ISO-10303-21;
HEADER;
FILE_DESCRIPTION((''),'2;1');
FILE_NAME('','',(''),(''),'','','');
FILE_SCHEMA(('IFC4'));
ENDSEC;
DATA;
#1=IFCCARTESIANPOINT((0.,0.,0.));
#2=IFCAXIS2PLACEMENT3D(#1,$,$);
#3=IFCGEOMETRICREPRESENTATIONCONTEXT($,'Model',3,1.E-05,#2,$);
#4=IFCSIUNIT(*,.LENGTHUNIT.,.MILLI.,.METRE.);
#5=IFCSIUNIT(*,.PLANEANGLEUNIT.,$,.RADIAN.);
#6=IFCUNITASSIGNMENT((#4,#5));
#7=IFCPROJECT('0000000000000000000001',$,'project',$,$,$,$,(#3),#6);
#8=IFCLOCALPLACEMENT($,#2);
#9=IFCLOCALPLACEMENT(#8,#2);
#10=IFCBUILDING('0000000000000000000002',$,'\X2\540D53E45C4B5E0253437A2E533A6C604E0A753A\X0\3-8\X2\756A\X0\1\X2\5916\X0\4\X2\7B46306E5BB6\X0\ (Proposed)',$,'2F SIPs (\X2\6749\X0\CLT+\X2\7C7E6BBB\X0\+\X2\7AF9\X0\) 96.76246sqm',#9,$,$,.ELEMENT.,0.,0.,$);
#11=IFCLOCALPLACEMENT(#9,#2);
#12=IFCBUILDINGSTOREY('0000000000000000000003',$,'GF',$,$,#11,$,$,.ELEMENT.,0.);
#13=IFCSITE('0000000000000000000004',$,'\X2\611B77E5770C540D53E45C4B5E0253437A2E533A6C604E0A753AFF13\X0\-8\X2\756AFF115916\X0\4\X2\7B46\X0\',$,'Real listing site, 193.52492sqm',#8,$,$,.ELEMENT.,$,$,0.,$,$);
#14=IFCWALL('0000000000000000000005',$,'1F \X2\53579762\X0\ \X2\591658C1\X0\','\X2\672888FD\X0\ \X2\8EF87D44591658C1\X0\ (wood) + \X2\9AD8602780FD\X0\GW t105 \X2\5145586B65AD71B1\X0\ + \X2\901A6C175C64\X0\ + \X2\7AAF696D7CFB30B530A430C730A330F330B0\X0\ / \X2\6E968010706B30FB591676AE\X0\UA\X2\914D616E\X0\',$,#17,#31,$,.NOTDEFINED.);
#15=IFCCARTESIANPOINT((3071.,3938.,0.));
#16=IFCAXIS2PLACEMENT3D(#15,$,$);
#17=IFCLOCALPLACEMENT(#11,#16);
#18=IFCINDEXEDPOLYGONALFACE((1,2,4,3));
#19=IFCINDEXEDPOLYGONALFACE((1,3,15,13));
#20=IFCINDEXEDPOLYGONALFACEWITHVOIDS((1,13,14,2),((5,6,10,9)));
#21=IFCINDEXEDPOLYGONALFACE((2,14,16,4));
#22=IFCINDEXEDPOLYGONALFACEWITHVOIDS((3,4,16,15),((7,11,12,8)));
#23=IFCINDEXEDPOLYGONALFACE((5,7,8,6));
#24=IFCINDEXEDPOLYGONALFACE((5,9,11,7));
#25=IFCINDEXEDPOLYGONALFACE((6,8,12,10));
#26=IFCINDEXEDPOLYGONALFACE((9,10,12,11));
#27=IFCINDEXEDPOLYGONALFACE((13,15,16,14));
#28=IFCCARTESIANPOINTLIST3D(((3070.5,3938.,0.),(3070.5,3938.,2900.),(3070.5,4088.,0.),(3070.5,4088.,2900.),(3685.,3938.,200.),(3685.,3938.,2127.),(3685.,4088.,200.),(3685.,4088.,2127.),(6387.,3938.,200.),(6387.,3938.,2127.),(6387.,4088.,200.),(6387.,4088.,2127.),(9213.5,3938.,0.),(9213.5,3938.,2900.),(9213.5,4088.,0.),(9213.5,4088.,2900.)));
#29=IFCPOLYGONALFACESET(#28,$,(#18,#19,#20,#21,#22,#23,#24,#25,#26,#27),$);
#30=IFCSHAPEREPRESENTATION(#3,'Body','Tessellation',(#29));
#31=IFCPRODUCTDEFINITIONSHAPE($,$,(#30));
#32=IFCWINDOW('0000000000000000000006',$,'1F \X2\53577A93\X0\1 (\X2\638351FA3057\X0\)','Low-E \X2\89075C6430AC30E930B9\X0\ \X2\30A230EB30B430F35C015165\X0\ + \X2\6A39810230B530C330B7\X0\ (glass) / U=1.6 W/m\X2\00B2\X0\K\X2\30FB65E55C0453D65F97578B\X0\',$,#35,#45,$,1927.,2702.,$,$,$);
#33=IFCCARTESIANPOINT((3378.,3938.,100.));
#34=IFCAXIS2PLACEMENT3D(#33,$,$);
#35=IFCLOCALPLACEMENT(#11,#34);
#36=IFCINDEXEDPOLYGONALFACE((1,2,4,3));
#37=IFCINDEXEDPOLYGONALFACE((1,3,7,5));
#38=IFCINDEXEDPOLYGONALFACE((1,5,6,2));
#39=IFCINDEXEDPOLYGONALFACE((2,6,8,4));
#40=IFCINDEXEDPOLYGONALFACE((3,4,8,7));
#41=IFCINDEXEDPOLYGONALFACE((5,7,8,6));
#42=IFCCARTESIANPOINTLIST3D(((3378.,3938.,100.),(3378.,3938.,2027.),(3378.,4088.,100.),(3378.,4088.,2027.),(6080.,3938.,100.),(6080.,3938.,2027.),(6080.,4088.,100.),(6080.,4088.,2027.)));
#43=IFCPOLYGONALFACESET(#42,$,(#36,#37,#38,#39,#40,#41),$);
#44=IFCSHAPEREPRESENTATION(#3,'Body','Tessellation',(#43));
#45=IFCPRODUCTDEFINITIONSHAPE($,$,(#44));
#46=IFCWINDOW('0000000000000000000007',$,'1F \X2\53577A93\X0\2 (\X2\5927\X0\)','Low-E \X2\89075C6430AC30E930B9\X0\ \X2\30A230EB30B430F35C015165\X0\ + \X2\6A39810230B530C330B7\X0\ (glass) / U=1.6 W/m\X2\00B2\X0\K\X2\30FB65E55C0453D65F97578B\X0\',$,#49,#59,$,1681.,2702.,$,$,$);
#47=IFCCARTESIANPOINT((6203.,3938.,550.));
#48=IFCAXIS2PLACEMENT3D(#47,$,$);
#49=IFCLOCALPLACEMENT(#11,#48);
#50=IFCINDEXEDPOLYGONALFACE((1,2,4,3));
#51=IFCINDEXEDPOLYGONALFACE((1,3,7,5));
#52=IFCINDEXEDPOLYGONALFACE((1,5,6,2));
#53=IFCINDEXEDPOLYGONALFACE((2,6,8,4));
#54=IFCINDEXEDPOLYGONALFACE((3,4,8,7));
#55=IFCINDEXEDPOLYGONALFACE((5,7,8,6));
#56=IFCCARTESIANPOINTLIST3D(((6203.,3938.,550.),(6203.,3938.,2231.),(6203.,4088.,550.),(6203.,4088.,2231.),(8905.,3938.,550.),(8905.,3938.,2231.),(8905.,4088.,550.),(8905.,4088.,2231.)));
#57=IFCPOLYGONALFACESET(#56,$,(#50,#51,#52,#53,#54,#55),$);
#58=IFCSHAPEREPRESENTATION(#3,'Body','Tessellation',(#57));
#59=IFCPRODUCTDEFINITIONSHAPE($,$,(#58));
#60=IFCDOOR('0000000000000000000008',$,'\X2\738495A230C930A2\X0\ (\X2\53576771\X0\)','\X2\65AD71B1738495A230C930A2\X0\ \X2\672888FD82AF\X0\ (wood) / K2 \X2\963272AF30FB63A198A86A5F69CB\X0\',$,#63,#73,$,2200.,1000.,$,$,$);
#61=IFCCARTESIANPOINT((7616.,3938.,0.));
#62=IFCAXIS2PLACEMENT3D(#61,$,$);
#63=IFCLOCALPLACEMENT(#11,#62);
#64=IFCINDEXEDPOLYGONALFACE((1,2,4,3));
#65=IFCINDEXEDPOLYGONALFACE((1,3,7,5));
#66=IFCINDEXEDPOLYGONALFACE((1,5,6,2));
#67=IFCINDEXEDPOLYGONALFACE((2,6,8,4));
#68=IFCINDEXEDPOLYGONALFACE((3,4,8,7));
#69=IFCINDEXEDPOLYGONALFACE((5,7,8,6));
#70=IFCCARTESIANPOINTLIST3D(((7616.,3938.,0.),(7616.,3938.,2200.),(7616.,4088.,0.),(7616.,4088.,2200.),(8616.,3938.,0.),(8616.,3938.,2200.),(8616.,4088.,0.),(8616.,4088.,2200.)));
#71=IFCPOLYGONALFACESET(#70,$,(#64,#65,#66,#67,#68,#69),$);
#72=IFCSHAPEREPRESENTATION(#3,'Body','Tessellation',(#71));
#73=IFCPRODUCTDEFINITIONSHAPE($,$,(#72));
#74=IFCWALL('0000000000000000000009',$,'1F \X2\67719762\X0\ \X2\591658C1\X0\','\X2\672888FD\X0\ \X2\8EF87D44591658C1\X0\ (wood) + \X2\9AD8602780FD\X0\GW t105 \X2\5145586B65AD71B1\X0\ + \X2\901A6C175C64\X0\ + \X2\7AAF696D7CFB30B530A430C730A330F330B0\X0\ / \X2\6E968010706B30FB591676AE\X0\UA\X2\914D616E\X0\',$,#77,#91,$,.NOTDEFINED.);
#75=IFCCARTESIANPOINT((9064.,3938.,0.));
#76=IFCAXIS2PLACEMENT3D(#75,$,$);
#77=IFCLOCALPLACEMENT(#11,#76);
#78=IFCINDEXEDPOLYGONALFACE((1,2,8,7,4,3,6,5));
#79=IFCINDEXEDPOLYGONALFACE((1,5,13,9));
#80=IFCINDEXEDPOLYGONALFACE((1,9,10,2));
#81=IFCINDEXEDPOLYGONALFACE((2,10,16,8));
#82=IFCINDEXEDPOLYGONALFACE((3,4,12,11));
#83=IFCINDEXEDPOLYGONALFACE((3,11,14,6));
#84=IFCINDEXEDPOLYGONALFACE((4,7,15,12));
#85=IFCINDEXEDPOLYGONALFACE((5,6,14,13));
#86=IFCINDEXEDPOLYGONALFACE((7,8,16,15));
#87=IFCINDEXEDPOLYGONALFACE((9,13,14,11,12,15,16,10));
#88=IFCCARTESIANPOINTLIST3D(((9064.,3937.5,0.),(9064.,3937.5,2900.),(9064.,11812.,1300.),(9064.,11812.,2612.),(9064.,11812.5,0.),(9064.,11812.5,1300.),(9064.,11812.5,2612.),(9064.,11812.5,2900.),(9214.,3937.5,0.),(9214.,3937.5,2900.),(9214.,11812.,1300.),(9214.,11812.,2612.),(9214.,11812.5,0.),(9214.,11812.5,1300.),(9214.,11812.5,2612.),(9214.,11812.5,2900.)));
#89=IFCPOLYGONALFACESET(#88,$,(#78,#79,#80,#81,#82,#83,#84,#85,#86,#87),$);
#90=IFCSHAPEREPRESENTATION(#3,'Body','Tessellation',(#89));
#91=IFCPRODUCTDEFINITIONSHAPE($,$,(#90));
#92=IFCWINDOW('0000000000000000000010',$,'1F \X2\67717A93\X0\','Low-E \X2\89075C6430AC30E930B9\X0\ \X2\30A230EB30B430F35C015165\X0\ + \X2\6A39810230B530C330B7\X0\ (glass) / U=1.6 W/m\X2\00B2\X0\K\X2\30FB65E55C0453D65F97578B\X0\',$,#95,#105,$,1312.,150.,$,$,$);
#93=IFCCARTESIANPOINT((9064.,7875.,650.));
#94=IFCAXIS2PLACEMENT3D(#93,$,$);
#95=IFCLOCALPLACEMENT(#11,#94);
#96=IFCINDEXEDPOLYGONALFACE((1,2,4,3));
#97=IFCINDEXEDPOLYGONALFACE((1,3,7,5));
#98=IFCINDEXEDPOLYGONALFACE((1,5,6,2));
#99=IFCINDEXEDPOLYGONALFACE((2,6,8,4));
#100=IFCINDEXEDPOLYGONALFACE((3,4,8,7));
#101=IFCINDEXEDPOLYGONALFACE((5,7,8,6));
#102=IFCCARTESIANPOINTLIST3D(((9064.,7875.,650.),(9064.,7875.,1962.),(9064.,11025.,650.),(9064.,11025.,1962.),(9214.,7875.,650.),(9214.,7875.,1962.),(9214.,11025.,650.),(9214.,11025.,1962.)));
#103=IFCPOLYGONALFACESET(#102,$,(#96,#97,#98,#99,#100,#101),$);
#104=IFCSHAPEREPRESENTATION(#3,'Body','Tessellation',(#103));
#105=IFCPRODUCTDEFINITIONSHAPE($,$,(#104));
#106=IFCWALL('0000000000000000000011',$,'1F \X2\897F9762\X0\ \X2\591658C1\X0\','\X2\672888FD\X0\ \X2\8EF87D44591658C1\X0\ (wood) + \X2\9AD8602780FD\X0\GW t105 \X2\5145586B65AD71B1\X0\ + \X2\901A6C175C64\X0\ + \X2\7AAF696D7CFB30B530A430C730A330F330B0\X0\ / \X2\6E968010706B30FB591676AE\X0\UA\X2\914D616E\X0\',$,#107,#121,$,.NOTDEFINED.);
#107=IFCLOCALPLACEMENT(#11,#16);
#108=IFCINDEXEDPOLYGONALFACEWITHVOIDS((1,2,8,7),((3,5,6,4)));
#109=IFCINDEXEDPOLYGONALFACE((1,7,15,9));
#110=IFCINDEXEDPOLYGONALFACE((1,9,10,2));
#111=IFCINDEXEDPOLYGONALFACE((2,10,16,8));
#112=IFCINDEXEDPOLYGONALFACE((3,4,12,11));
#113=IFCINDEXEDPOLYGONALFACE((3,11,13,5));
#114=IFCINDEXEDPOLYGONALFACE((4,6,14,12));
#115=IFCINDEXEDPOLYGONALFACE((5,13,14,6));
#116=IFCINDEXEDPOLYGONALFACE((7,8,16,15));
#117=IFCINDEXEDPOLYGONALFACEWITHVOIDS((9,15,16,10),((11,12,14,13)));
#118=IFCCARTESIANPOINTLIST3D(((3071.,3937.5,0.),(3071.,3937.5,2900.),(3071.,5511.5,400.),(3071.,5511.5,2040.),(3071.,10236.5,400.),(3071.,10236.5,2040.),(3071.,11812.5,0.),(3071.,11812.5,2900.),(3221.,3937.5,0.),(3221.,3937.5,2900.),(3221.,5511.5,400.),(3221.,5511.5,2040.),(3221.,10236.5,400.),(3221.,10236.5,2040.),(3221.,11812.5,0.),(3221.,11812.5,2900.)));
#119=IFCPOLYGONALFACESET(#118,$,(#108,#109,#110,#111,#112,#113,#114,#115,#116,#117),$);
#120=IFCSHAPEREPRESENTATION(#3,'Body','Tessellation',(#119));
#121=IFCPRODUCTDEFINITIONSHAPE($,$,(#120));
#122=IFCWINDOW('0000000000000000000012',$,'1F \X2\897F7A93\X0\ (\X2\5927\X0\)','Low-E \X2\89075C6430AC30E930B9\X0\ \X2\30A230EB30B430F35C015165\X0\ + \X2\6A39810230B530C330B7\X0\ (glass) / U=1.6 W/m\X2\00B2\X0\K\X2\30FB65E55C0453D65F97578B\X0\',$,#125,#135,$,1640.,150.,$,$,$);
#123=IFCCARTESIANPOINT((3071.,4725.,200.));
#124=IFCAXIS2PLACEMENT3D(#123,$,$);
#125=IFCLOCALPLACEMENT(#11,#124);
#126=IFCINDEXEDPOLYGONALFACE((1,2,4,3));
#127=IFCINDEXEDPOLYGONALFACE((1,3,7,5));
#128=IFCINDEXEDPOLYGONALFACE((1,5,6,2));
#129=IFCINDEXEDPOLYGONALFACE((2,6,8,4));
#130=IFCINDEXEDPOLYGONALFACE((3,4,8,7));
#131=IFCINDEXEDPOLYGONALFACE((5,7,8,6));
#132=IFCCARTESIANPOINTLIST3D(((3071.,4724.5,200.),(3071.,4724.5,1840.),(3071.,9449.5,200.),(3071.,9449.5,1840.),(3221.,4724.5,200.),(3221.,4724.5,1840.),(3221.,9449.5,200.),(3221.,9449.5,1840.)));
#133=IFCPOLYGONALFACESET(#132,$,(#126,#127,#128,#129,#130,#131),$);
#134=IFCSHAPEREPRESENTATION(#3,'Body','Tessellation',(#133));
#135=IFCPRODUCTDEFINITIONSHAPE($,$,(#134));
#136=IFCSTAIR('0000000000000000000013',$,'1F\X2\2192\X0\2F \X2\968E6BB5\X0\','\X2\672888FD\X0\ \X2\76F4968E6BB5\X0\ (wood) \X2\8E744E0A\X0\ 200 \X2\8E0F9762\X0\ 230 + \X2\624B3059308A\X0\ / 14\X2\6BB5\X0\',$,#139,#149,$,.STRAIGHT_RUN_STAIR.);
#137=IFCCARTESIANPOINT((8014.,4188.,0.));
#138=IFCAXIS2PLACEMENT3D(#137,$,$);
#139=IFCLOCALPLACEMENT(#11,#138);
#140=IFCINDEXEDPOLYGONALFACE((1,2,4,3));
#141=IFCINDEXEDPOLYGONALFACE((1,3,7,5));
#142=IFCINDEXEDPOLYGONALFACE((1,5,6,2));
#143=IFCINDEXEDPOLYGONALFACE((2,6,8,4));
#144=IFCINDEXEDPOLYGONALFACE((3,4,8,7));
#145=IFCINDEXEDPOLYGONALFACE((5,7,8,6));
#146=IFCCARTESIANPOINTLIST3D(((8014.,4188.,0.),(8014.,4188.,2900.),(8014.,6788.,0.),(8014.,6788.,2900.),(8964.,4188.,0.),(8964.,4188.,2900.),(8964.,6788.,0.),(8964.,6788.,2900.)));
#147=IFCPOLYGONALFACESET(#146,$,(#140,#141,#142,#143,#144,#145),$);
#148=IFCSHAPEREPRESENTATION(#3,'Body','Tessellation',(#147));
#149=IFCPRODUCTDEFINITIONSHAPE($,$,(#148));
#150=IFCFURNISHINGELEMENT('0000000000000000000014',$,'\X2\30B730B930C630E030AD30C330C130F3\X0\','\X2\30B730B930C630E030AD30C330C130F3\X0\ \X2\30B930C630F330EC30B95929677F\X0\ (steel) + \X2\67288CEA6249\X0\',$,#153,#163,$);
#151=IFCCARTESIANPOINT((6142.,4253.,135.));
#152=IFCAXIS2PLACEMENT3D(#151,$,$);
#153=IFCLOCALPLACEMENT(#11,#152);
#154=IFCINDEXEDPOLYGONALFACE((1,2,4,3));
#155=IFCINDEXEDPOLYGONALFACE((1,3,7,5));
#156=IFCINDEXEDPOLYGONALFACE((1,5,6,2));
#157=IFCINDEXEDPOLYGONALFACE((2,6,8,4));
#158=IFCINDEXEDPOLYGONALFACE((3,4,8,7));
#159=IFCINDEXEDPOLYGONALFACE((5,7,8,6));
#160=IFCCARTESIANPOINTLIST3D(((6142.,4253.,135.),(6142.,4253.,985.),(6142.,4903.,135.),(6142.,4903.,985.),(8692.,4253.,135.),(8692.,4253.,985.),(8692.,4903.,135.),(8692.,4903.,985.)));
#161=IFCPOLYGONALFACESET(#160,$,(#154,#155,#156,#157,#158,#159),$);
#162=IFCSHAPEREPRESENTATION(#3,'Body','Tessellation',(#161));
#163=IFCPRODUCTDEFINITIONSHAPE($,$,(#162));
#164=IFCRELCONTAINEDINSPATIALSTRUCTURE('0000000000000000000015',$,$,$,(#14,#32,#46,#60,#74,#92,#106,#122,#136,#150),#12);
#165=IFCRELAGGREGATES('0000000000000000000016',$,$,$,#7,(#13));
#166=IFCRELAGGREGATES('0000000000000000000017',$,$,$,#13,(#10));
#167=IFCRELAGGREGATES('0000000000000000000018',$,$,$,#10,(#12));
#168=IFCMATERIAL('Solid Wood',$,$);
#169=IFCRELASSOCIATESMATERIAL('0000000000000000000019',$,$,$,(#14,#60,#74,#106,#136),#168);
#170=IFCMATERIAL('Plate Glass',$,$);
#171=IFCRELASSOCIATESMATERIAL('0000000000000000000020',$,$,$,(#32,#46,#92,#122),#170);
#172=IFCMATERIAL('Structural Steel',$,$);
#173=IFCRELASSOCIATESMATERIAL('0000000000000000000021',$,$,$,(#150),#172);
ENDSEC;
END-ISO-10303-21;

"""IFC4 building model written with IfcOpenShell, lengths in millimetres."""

from ifc_helpers import new_model, si_unit, frame, frame_2d, origin, place, context, project, spatial, rectangle, extrude, material, element, fill, save


model = new_model("IFC4")

# Units and contexts
model_context = context("Model", 3, precision=1e-05, world=origin())
ifc_project = project(units=[si_unit("LENGTHUNIT", "METRE", prefix="MILLI"), si_unit("PLANEANGLEUNIT", "RADIAN")], contexts=[model_context])

# Site, building, storey
site_placement = place(None, origin())
site = spatial("IfcSite", under=ifc_project, at=site_placement, Name="愛知県名古屋市千種区池上町３-8番１外4筆", ObjectType="Real listing site, 193.52492sqm", CompositionType="ELEMENT", RefElevation=0.0)
building_placement = place(site_placement, origin())
building = spatial("IfcBuilding", under=site, at=building_placement, Name="名古屋市千種区池上町3-8番1外4筆の家 (Proposed)", ObjectType="2F SIPs (杉CLT+籾殻+竹) 96.76246sqm", CompositionType="ELEMENT", ElevationOfRefHeight=0.0, ElevationOfTerrain=0.0)
storey_placement = place(building_placement, origin())
storey = spatial("IfcBuildingStorey", under=building, at=storey_placement, Name="GF", CompositionType="ELEMENT", Elevation=0.0)

# Shared definitions
ifc_material_1 = material(Name="Solid Wood")

# Wall, openings, windows, door
wall_1_placement = place(storey_placement, frame((3071.0, 3938.0, 0.0)))
wall_1 = element("IfcWall", 1, at=wall_1_placement, inside=storey, material=ifc_material_1, Name="1F 南面 外壁", Description="木製 軸組外壁 (wood) + 高性能GW t105 充填断熱 + 通気層 + 窯業系サイディング / 準耐火・外皮UA配慮", PredefinedType="NOTDEFINED", context=model_context, shape_type="SweptSolid", body=[
    extrude(rectangle(XDim=6143.0, YDim=150.0, at=frame_2d((3071.0, 75.0))), frame((3071.0, 3938.0, 0.0)), (0.0, 0.0, 1.0), 2900.0),
])
opening_1_placement = place(storey_placement, frame((3378.0, 3938.0, 100.0)))
opening_1 = element("IfcOpeningElement", 2, at=opening_1_placement, cuts=wall_1, PredefinedType="NOTDEFINED", context=model_context, shape_type="SweptSolid", body=[
    extrude(rectangle(XDim=2702.0, YDim=150.0, at=frame_2d((1351.0, 75.0))), frame((3378.0, 3938.0, 100.0)), (0.0, 0.0, 1.0), 1927.0),
])
opening_2_placement = place(storey_placement, frame((6203.0, 3938.0, 550.0)))
opening_2 = element("IfcOpeningElement", 3, at=opening_2_placement, cuts=wall_1, PredefinedType="NOTDEFINED", context=model_context, shape_type="SweptSolid", body=[
    extrude(rectangle(XDim=2702.0, YDim=150.0, at=frame_2d((1351.0, 75.0))), frame((6203.0, 3938.0, 550.0)), (0.0, 0.0, 1.0), 1681.0),
])
opening_3_placement = place(storey_placement, frame((7616.0, 3938.0, 0.0)))
opening_3 = element("IfcOpeningElement", 4, at=opening_3_placement, cuts=wall_1, PredefinedType="NOTDEFINED", context=model_context, shape_type="SweptSolid", body=[
    extrude(rectangle(XDim=1000.0, YDim=150.0, at=frame_2d((500.0, 75.0))), frame((7616.0, 3938.0, 0.0)), (0.0, 0.0, 1.0), 2200.0),
])
ifc_material_2 = material(Name="Plate Glass")
window_1_placement = place(storey_placement, frame((3378.0, 3938.0, 100.0)))
window_1 = element("IfcWindow", 5, at=window_1_placement, inside=storey, material=ifc_material_2, Name="1F 南窓1 (掃出し)", Description="Low-E 複層ガラス アルゴン封入 + 樹脂サッシ (glass) / U=1.6 W/m²K・日射取得型", OverallHeight=1927.0, OverallWidth=2702.0, context=model_context, shape_type="SweptSolid", body=[
    extrude(rectangle(XDim=2702.0, YDim=150.0, at=frame_2d((1351.0, 75.0))), frame((3378.0, 3938.0, 100.0)), (0.0, 0.0, 1.0), 1927.0),
])
fill(opening_1, window_1)
window_2_placement = place(storey_placement, frame((6203.0, 3938.0, 550.0)))
window_2 = element("IfcWindow", 6, at=window_2_placement, inside=storey, material=ifc_material_2, Name="1F 南窓2 (大)", Description="Low-E 複層ガラス アルゴン封入 + 樹脂サッシ (glass) / U=1.6 W/m²K・日射取得型", OverallHeight=1681.0, OverallWidth=2702.0, context=model_context, shape_type="SweptSolid", body=[
    extrude(rectangle(XDim=2702.0, YDim=150.0, at=frame_2d((1351.0, 75.0))), frame((6203.0, 3938.0, 550.0)), (0.0, 0.0, 1.0), 1681.0),
])
fill(opening_2, window_2)
door_placement = place(storey_placement, frame((7616.0, 3938.0, 0.0)))
door = element("IfcDoor", 7, at=door_placement, inside=storey, material=ifc_material_1, Name="玄関ドア (南東)", Description="断熱玄関ドア 木製芯 (wood) / K2 防犯・採風機構", OverallHeight=2200.0, OverallWidth=1000.0, context=model_context, shape_type="SweptSolid", body=[
    extrude(rectangle(XDim=1000.0, YDim=150.0, at=frame_2d((500.0, 75.0))), frame((7616.0, 3938.0, 0.0)), (0.0, 0.0, 1.0), 2200.0),
])
fill(opening_3, door)

# Walls, openings, windows
wall_2_placement = place(storey_placement, frame((9064.0, 3938.0, 0.0)))
wall_2 = element("IfcWall", 8, at=wall_2_placement, inside=storey, material=ifc_material_1, Name="1F 東面 外壁", Description="木製 軸組外壁 (wood) + 高性能GW t105 充填断熱 + 通気層 + 窯業系サイディング / 準耐火・外皮UA配慮", PredefinedType="NOTDEFINED", context=model_context, shape_type="SweptSolid", body=[
    extrude(rectangle(XDim=150.0, YDim=7875.0, at=frame_2d((75.0, 3937.0))), frame((9064.0, 3938.0, 0.0)), (0.0, 0.0, 1.0), 2900.0),
])
opening_4_placement = place(storey_placement, frame((9064.0, 7875.0, 650.0)))
opening_4 = element("IfcOpeningElement", 9, at=opening_4_placement, cuts=wall_2, PredefinedType="NOTDEFINED", context=model_context, shape_type="SweptSolid", body=[
    extrude(rectangle(XDim=150.0, YDim=3150.0, at=frame_2d((75.0, 1575.0))), frame((9064.0, 7875.0, 650.0)), (0.0, 0.0, 1.0), 1312.0),
])
window_3_placement = place(storey_placement, frame((9064.0, 7875.0, 650.0)))
window_3 = element("IfcWindow", 10, at=window_3_placement, inside=storey, material=ifc_material_2, Name="1F 東窓", Description="Low-E 複層ガラス アルゴン封入 + 樹脂サッシ (glass) / U=1.6 W/m²K・日射取得型", OverallHeight=1312.0, OverallWidth=150.0, context=model_context, shape_type="SweptSolid", body=[
    extrude(rectangle(XDim=150.0, YDim=3150.0, at=frame_2d((75.0, 1575.0))), frame((9064.0, 7875.0, 650.0)), (0.0, 0.0, 1.0), 1312.0),
])
fill(opening_4, window_3)
wall_3_placement = place(storey_placement, frame((3071.0, 3938.0, 0.0)))
wall_3 = element("IfcWall", 11, at=wall_3_placement, inside=storey, material=ifc_material_1, Name="1F 西面 外壁", Description="木製 軸組外壁 (wood) + 高性能GW t105 充填断熱 + 通気層 + 窯業系サイディング / 準耐火・外皮UA配慮", PredefinedType="NOTDEFINED", context=model_context, shape_type="SweptSolid", body=[
    extrude(rectangle(XDim=150.0, YDim=7875.0, at=frame_2d((75.0, 3937.0))), frame((3071.0, 3938.0, 0.0)), (0.0, 0.0, 1.0), 2900.0),
])
opening_5_placement = place(storey_placement, frame((3071.0, 4725.0, 200.0)))
opening_5 = element("IfcOpeningElement", 12, at=opening_5_placement, cuts=wall_3, PredefinedType="NOTDEFINED", context=model_context, shape_type="SweptSolid", body=[
    extrude(rectangle(XDim=150.0, YDim=4725.0, at=frame_2d((75.0, 2362.0))), frame((3071.0, 4725.0, 200.0)), (0.0, 0.0, 1.0), 1640.0),
])
window_4_placement = place(storey_placement, frame((3071.0, 4725.0, 200.0)))
window_4 = element("IfcWindow", 13, at=window_4_placement, inside=storey, material=ifc_material_2, Name="1F 西窓 (大)", Description="Low-E 複層ガラス アルゴン封入 + 樹脂サッシ (glass) / U=1.6 W/m²K・日射取得型", OverallHeight=1640.0, OverallWidth=150.0, context=model_context, shape_type="SweptSolid", body=[
    extrude(rectangle(XDim=150.0, YDim=4725.0, at=frame_2d((75.0, 2362.0))), frame((3071.0, 4725.0, 200.0)), (0.0, 0.0, 1.0), 1640.0),
])
fill(opening_5, window_4)

# Stair
stair_placement = place(storey_placement, frame((8014.0, 4188.0, 0.0)))
element("IfcStair", 14, at=stair_placement, inside=storey, material=ifc_material_1, Name="1F→2F 階段", Description="木製 直階段 (wood) 蹴上 200 踏面 230 + 手すり / 14段", PredefinedType="STRAIGHT_RUN_STAIR", context=model_context, shape_type="SweptSolid", body=[
    extrude(rectangle(XDim=950.0, YDim=2600.0, at=frame_2d((475.0, 1300.0))), frame((8014.0, 4188.0, 0.0)), (0.0, 0.0, 1.0), 2900.0),
])

# Furnishing element
ifc_material_3 = material(Name="Structural Steel")
furnishing_placement = place(storey_placement, frame((6142.0, 4253.0, 135.0)))
element("IfcFurnishingElement", 15, at=furnishing_placement, inside=storey, material=ifc_material_3, Name="システムキッチン", Description="システムキッチン ステンレス天板 (steel) + 木質扉", context=model_context, shape_type="SweptSolid", body=[
    extrude(rectangle(XDim=2550.0, YDim=650.0, at=frame_2d((1275.0, 325.0))), frame((6142.0, 4253.0, 135.0)), (0.0, 0.0, 1.0), 850.0),
])

save(model, "model.ifc")
